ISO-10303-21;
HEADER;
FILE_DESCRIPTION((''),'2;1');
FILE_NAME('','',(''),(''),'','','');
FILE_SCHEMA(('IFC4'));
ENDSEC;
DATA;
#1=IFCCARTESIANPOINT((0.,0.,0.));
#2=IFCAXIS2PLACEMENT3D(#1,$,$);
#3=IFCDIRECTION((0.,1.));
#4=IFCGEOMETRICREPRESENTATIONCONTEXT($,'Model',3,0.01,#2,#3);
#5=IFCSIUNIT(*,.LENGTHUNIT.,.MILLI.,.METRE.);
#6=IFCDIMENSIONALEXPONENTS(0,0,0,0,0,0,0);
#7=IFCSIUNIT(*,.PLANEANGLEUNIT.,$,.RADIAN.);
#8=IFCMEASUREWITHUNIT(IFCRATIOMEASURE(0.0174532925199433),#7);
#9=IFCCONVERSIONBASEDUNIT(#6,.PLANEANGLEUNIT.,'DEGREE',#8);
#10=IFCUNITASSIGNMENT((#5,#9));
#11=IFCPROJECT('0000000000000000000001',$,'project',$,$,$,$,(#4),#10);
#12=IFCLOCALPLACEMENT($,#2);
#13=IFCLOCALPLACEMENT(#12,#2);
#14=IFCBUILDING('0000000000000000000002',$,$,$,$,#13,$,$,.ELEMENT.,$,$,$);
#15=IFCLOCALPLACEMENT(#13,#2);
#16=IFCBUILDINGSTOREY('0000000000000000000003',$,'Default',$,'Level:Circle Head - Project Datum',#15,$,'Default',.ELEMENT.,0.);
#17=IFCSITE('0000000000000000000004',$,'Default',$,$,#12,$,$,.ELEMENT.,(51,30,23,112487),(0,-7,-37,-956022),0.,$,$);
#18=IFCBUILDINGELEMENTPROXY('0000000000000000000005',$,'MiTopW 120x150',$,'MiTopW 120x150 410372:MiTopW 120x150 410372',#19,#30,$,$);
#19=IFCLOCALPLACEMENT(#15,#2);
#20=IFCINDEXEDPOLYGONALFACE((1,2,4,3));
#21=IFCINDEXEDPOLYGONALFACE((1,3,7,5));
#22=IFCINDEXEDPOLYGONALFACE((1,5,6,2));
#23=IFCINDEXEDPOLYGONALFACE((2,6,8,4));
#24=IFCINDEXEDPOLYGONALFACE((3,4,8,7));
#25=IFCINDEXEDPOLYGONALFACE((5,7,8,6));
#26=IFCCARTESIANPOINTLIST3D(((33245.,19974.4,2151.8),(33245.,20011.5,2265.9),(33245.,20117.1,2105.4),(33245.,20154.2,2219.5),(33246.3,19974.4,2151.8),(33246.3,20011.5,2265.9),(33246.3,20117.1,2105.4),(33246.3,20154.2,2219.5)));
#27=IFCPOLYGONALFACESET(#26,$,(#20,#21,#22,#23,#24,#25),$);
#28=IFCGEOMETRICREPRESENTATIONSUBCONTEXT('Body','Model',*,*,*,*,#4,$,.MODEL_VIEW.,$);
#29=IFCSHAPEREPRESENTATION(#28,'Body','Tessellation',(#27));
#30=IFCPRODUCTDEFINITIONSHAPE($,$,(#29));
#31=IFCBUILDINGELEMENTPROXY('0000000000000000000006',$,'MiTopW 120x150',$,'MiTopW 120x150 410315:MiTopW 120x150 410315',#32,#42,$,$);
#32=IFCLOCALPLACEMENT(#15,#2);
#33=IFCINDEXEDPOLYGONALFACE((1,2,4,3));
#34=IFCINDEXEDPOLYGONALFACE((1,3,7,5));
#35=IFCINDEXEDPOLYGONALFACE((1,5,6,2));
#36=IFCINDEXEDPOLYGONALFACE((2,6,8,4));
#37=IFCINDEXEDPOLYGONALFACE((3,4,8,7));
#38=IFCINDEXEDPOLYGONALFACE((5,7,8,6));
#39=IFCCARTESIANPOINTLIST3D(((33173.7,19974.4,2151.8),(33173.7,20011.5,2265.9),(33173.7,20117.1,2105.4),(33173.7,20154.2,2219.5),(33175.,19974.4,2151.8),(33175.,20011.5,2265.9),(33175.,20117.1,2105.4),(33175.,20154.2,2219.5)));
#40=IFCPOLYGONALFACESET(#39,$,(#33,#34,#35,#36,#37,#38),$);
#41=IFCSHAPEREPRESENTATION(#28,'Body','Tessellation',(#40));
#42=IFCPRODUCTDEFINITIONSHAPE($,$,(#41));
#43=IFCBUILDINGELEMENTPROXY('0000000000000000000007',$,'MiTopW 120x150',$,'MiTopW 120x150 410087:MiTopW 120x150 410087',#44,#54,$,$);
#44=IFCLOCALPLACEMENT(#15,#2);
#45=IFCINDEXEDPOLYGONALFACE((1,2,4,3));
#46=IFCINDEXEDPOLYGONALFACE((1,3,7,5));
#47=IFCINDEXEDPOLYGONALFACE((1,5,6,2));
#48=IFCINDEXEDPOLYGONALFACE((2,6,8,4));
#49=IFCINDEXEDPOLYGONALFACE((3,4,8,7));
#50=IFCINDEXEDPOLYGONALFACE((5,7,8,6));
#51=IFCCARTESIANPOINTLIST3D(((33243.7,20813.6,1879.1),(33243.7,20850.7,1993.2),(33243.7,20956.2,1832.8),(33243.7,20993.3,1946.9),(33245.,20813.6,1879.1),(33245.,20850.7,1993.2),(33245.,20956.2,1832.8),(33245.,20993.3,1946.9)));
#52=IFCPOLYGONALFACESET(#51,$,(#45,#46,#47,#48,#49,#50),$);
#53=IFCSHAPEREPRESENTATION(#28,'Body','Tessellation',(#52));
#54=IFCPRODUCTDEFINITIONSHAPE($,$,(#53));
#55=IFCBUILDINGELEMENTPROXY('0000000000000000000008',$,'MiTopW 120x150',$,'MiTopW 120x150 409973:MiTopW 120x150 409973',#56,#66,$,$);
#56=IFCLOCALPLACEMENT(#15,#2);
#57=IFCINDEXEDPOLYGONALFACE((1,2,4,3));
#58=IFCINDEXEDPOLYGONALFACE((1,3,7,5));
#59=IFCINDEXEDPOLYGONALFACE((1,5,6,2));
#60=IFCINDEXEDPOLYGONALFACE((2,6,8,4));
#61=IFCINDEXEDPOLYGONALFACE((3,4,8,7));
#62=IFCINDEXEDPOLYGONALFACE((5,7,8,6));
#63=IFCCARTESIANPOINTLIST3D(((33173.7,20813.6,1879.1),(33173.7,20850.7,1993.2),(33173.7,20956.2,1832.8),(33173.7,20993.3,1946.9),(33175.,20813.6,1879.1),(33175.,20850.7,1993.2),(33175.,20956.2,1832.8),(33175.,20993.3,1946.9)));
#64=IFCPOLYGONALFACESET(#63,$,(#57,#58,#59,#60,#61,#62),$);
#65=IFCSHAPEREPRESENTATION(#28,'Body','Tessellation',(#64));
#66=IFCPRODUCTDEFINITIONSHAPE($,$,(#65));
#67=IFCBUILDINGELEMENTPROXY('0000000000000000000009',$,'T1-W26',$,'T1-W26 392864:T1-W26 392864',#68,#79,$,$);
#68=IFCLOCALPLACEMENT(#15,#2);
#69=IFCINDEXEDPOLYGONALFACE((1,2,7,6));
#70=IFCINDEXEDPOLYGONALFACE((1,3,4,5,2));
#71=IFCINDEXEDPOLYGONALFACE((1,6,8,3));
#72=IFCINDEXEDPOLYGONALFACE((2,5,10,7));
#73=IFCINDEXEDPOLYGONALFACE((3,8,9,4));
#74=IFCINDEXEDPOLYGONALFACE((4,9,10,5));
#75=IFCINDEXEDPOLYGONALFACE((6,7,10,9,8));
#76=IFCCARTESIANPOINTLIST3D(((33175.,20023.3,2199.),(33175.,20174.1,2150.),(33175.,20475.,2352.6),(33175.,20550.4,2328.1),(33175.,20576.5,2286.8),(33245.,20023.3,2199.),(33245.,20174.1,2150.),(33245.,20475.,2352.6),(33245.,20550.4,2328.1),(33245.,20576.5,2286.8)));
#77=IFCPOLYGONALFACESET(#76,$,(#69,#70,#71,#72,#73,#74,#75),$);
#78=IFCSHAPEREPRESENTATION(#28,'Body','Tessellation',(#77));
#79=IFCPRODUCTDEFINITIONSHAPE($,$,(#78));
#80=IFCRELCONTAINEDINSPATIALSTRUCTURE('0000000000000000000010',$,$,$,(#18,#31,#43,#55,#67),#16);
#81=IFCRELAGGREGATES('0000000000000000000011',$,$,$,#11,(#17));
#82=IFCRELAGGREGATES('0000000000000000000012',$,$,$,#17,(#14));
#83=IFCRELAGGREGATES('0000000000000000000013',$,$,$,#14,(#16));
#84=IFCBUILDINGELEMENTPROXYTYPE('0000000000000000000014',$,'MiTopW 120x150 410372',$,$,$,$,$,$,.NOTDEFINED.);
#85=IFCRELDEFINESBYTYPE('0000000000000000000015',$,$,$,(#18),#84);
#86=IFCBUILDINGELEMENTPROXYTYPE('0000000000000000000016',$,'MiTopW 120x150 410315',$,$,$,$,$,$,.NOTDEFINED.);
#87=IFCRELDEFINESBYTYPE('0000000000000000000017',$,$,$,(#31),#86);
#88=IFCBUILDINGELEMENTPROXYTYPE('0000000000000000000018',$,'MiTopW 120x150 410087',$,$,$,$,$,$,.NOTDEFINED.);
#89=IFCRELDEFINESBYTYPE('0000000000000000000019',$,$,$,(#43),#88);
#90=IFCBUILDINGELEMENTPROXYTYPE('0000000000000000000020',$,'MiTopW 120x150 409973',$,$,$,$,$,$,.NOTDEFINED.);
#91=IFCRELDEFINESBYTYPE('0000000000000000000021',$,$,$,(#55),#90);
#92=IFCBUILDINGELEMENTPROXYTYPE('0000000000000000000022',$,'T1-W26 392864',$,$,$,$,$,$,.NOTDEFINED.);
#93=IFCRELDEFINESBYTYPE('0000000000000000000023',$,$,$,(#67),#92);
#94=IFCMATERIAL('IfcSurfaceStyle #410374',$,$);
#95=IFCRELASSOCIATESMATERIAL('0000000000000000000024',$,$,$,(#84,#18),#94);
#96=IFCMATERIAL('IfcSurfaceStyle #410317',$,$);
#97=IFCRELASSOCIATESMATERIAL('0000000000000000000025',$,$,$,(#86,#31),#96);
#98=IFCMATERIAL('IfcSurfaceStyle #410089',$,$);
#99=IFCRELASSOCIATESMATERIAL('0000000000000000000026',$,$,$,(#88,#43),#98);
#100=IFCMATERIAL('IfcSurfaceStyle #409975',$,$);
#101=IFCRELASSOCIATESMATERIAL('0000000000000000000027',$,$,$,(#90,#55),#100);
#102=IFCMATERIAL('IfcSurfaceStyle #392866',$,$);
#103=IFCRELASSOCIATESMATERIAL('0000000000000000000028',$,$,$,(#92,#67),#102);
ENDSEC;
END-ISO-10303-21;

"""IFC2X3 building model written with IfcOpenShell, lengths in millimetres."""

from ifc_helpers import new_model, entity, si_unit, converted_unit, direction, frame, origin, place, context, subcontext, project, spatial, polyline, outline, extrude, source, transform, mapped, material, type_object, type_shapes, element, save


model = new_model("IFC2X3")

# Units and contexts
model_context = context("Model", 3, precision=0.01, world=origin(), true_north=direction((0.0, 1.0)))
body_context = subcontext(model_context, "Body", "Model", "MODEL_VIEW")
ifc_project = project(units=[si_unit("LENGTHUNIT", "METRE", prefix="MILLI"), converted_unit("PLANEANGLEUNIT", "DEGREE", entity("IfcRatioMeasure", 0.0174532925199433), si_unit("PLANEANGLEUNIT", "RADIAN"), dimensions=[0, 0, 0, 0, 0, 0, 0])], contexts=[model_context])

# Site, building, storey
site_placement = place(None, origin())
site = spatial("IfcSite", under=ifc_project, at=site_placement, Name="Default", CompositionType="ELEMENT", RefLatitude=(51, 30, 23, 112487), RefLongitude=(0, -7, -37, -956022), RefElevation=0.0)
building_placement = place(site_placement, origin())
building = spatial("IfcBuilding", under=site, at=building_placement, CompositionType="ELEMENT")
storey_placement = place(building_placement, origin())
storey = spatial("IfcBuildingStorey", under=building, at=storey_placement, Name="Default", ObjectType="Level:Circle Head - Project Datum", LongName="Default", CompositionType="ELEMENT", Elevation=0.0)

# Building element proxies
ifc_material_1 = material(Name="IfcSurfaceStyle #410374")
building_element_proxy_type_1 = type_object("IfcBuildingElementProxyType", Name="MiTopW 120x150 410372", PredefinedType="NOTDEFINED", material=ifc_material_1)
shared_shape_1 = source(origin(), body_context, "Body", "SweptSolid", [
    extrude(outline(polyline([(-75.0, -60.0), (75.0, -60.0), (75.0, 60.0), (-75.0, 60.0), (-75.0, -60.0)])), frame((75.0, 60.0, 0.0), z_axis=(0.0, 0.0, 1.0), x_axis=(-1.0, 0.0, 0.0)), (0.0, 0.0, 1.0), 1.3),
])
type_shapes(building_element_proxy_type_1, [shared_shape_1])
proxy_1_placement = place(building_placement, frame((33246.3, 20117.1, 2105.4), z_axis=(-1.0, 0.0, 0.0), x_axis=(0.0, -0.951057, 0.309017)))
element("IfcBuildingElementProxy", 1, at=proxy_1_placement, inside=storey, type_object=building_element_proxy_type_1, material=ifc_material_1, Name="MiTopW 120x150", ObjectType="MiTopW 120x150 410372:MiTopW 120x150 410372", context=body_context, shape_type="MappedRepresentation", body=[
    mapped(shared_shape_1, transform((0.0, 0.0, 0.0), scale=1.0)),
])
ifc_material_2 = material(Name="IfcSurfaceStyle #410317")
building_element_proxy_type_2 = type_object("IfcBuildingElementProxyType", Name="MiTopW 120x150 410315", PredefinedType="NOTDEFINED", material=ifc_material_2)
shared_shape_2 = source(origin(), body_context, "Body", "SweptSolid", [
    extrude(outline(polyline([(-75.0, -60.0), (75.0, -60.0), (75.0, 60.0), (-75.0, 60.0), (-75.0, -60.0)])), frame((75.0, 60.0, 0.0), z_axis=(0.0, 0.0, 1.0), x_axis=(-1.0, 0.0, 0.0)), (0.0, 0.0, 1.0), 1.3),
])
type_shapes(building_element_proxy_type_2, [shared_shape_2])
proxy_2_placement = place(building_placement, frame((33175.0, 20117.1, 2105.4), z_axis=(-1.0, 0.0, 0.0), x_axis=(0.0, -0.951057, 0.309017)))
element("IfcBuildingElementProxy", 2, at=proxy_2_placement, inside=storey, type_object=building_element_proxy_type_2, material=ifc_material_2, Name="MiTopW 120x150", ObjectType="MiTopW 120x150 410315:MiTopW 120x150 410315", context=body_context, shape_type="MappedRepresentation", body=[
    mapped(shared_shape_2, transform((0.0, 0.0, 0.0), scale=1.0)),
])
ifc_material_3 = material(Name="IfcSurfaceStyle #410089")
building_element_proxy_type_3 = type_object("IfcBuildingElementProxyType", Name="MiTopW 120x150 410087", PredefinedType="NOTDEFINED", material=ifc_material_3)
shared_shape_3 = source(origin(), body_context, "Body", "SweptSolid", [
    extrude(outline(polyline([(-75.0, -60.0), (75.0, -60.0), (75.0, 60.0), (-75.0, 60.0), (-75.0, -60.0)])), frame((75.0, 60.0, 0.0), z_axis=(0.0, 0.0, 1.0), x_axis=(-1.0, 0.0, 0.0)), (0.0, 0.0, 1.0), 1.3),
])
type_shapes(building_element_proxy_type_3, [shared_shape_3])
proxy_3_placement = place(building_placement, frame((33245.0, 20956.2, 1832.8), z_axis=(-1.0, 0.0, 0.0), x_axis=(0.0, -0.951057, 0.309017)))
element("IfcBuildingElementProxy", 3, at=proxy_3_placement, inside=storey, type_object=building_element_proxy_type_3, material=ifc_material_3, Name="MiTopW 120x150", ObjectType="MiTopW 120x150 410087:MiTopW 120x150 410087", context=body_context, shape_type="MappedRepresentation", body=[
    mapped(shared_shape_3, transform((0.0, 0.0, 0.0), scale=1.0)),
])
ifc_material_4 = material(Name="IfcSurfaceStyle #409975")
building_element_proxy_type_4 = type_object("IfcBuildingElementProxyType", Name="MiTopW 120x150 409973", PredefinedType="NOTDEFINED", material=ifc_material_4)
shared_shape_4 = source(origin(), body_context, "Body", "SweptSolid", [
    extrude(outline(polyline([(-75.0, -60.0), (75.0, -60.0), (75.0, 60.0), (-75.0, 60.0), (-75.0, -60.0)])), frame((75.0, 60.0, 0.0), z_axis=(0.0, 0.0, 1.0), x_axis=(-1.0, 0.0, 0.0)), (0.0, 0.0, 1.0), 1.3),
])
type_shapes(building_element_proxy_type_4, [shared_shape_4])
proxy_4_placement = place(building_placement, frame((33175.0, 20956.2, 1832.8), z_axis=(-1.0, 0.0, 0.0), x_axis=(0.0, -0.951057, 0.309017)))
element("IfcBuildingElementProxy", 4, at=proxy_4_placement, inside=storey, type_object=building_element_proxy_type_4, material=ifc_material_4, Name="MiTopW 120x150", ObjectType="MiTopW 120x150 409973:MiTopW 120x150 409973", context=body_context, shape_type="MappedRepresentation", body=[
    mapped(shared_shape_4, transform((0.0, 0.0, 0.0), scale=1.0)),
])
ifc_material_5 = material(Name="IfcSurfaceStyle #392866")
building_element_proxy_type_5 = type_object("IfcBuildingElementProxyType", Name="T1-W26 392864", PredefinedType="NOTDEFINED", material=ifc_material_5)
shared_shape_5 = source(origin(), body_context, "Body", "SweptSolid", [
    extrude(outline(polyline([(-339.4, -47.5), (137.7, -47.5), (201.3, 0.0), (212.7, 47.5), (-212.3, 47.5), (-339.4, -47.5)])), frame((212.7, 47.5, 0.0), z_axis=(0.0, 0.0, 1.0), x_axis=(-1.0, 0.0, 0.0)), (0.0, 0.0, 1.0), 70.0),
])
type_shapes(building_element_proxy_type_5, [shared_shape_5])
proxy_5_placement = place(building_placement, frame((33245.0, 20576.5, 2286.8), z_axis=(-1.0, 0.0, 0.0), x_axis=(0.0, -0.946744, -0.321988)))
element("IfcBuildingElementProxy", 5, at=proxy_5_placement, inside=storey, type_object=building_element_proxy_type_5, material=ifc_material_5, Name="T1-W26", ObjectType="T1-W26 392864:T1-W26 392864", context=body_context, shape_type="MappedRepresentation", body=[
    mapped(shared_shape_5, transform((0.0, 0.0, 0.0), scale=1.0)),
])

save(model, "model.ifc")
